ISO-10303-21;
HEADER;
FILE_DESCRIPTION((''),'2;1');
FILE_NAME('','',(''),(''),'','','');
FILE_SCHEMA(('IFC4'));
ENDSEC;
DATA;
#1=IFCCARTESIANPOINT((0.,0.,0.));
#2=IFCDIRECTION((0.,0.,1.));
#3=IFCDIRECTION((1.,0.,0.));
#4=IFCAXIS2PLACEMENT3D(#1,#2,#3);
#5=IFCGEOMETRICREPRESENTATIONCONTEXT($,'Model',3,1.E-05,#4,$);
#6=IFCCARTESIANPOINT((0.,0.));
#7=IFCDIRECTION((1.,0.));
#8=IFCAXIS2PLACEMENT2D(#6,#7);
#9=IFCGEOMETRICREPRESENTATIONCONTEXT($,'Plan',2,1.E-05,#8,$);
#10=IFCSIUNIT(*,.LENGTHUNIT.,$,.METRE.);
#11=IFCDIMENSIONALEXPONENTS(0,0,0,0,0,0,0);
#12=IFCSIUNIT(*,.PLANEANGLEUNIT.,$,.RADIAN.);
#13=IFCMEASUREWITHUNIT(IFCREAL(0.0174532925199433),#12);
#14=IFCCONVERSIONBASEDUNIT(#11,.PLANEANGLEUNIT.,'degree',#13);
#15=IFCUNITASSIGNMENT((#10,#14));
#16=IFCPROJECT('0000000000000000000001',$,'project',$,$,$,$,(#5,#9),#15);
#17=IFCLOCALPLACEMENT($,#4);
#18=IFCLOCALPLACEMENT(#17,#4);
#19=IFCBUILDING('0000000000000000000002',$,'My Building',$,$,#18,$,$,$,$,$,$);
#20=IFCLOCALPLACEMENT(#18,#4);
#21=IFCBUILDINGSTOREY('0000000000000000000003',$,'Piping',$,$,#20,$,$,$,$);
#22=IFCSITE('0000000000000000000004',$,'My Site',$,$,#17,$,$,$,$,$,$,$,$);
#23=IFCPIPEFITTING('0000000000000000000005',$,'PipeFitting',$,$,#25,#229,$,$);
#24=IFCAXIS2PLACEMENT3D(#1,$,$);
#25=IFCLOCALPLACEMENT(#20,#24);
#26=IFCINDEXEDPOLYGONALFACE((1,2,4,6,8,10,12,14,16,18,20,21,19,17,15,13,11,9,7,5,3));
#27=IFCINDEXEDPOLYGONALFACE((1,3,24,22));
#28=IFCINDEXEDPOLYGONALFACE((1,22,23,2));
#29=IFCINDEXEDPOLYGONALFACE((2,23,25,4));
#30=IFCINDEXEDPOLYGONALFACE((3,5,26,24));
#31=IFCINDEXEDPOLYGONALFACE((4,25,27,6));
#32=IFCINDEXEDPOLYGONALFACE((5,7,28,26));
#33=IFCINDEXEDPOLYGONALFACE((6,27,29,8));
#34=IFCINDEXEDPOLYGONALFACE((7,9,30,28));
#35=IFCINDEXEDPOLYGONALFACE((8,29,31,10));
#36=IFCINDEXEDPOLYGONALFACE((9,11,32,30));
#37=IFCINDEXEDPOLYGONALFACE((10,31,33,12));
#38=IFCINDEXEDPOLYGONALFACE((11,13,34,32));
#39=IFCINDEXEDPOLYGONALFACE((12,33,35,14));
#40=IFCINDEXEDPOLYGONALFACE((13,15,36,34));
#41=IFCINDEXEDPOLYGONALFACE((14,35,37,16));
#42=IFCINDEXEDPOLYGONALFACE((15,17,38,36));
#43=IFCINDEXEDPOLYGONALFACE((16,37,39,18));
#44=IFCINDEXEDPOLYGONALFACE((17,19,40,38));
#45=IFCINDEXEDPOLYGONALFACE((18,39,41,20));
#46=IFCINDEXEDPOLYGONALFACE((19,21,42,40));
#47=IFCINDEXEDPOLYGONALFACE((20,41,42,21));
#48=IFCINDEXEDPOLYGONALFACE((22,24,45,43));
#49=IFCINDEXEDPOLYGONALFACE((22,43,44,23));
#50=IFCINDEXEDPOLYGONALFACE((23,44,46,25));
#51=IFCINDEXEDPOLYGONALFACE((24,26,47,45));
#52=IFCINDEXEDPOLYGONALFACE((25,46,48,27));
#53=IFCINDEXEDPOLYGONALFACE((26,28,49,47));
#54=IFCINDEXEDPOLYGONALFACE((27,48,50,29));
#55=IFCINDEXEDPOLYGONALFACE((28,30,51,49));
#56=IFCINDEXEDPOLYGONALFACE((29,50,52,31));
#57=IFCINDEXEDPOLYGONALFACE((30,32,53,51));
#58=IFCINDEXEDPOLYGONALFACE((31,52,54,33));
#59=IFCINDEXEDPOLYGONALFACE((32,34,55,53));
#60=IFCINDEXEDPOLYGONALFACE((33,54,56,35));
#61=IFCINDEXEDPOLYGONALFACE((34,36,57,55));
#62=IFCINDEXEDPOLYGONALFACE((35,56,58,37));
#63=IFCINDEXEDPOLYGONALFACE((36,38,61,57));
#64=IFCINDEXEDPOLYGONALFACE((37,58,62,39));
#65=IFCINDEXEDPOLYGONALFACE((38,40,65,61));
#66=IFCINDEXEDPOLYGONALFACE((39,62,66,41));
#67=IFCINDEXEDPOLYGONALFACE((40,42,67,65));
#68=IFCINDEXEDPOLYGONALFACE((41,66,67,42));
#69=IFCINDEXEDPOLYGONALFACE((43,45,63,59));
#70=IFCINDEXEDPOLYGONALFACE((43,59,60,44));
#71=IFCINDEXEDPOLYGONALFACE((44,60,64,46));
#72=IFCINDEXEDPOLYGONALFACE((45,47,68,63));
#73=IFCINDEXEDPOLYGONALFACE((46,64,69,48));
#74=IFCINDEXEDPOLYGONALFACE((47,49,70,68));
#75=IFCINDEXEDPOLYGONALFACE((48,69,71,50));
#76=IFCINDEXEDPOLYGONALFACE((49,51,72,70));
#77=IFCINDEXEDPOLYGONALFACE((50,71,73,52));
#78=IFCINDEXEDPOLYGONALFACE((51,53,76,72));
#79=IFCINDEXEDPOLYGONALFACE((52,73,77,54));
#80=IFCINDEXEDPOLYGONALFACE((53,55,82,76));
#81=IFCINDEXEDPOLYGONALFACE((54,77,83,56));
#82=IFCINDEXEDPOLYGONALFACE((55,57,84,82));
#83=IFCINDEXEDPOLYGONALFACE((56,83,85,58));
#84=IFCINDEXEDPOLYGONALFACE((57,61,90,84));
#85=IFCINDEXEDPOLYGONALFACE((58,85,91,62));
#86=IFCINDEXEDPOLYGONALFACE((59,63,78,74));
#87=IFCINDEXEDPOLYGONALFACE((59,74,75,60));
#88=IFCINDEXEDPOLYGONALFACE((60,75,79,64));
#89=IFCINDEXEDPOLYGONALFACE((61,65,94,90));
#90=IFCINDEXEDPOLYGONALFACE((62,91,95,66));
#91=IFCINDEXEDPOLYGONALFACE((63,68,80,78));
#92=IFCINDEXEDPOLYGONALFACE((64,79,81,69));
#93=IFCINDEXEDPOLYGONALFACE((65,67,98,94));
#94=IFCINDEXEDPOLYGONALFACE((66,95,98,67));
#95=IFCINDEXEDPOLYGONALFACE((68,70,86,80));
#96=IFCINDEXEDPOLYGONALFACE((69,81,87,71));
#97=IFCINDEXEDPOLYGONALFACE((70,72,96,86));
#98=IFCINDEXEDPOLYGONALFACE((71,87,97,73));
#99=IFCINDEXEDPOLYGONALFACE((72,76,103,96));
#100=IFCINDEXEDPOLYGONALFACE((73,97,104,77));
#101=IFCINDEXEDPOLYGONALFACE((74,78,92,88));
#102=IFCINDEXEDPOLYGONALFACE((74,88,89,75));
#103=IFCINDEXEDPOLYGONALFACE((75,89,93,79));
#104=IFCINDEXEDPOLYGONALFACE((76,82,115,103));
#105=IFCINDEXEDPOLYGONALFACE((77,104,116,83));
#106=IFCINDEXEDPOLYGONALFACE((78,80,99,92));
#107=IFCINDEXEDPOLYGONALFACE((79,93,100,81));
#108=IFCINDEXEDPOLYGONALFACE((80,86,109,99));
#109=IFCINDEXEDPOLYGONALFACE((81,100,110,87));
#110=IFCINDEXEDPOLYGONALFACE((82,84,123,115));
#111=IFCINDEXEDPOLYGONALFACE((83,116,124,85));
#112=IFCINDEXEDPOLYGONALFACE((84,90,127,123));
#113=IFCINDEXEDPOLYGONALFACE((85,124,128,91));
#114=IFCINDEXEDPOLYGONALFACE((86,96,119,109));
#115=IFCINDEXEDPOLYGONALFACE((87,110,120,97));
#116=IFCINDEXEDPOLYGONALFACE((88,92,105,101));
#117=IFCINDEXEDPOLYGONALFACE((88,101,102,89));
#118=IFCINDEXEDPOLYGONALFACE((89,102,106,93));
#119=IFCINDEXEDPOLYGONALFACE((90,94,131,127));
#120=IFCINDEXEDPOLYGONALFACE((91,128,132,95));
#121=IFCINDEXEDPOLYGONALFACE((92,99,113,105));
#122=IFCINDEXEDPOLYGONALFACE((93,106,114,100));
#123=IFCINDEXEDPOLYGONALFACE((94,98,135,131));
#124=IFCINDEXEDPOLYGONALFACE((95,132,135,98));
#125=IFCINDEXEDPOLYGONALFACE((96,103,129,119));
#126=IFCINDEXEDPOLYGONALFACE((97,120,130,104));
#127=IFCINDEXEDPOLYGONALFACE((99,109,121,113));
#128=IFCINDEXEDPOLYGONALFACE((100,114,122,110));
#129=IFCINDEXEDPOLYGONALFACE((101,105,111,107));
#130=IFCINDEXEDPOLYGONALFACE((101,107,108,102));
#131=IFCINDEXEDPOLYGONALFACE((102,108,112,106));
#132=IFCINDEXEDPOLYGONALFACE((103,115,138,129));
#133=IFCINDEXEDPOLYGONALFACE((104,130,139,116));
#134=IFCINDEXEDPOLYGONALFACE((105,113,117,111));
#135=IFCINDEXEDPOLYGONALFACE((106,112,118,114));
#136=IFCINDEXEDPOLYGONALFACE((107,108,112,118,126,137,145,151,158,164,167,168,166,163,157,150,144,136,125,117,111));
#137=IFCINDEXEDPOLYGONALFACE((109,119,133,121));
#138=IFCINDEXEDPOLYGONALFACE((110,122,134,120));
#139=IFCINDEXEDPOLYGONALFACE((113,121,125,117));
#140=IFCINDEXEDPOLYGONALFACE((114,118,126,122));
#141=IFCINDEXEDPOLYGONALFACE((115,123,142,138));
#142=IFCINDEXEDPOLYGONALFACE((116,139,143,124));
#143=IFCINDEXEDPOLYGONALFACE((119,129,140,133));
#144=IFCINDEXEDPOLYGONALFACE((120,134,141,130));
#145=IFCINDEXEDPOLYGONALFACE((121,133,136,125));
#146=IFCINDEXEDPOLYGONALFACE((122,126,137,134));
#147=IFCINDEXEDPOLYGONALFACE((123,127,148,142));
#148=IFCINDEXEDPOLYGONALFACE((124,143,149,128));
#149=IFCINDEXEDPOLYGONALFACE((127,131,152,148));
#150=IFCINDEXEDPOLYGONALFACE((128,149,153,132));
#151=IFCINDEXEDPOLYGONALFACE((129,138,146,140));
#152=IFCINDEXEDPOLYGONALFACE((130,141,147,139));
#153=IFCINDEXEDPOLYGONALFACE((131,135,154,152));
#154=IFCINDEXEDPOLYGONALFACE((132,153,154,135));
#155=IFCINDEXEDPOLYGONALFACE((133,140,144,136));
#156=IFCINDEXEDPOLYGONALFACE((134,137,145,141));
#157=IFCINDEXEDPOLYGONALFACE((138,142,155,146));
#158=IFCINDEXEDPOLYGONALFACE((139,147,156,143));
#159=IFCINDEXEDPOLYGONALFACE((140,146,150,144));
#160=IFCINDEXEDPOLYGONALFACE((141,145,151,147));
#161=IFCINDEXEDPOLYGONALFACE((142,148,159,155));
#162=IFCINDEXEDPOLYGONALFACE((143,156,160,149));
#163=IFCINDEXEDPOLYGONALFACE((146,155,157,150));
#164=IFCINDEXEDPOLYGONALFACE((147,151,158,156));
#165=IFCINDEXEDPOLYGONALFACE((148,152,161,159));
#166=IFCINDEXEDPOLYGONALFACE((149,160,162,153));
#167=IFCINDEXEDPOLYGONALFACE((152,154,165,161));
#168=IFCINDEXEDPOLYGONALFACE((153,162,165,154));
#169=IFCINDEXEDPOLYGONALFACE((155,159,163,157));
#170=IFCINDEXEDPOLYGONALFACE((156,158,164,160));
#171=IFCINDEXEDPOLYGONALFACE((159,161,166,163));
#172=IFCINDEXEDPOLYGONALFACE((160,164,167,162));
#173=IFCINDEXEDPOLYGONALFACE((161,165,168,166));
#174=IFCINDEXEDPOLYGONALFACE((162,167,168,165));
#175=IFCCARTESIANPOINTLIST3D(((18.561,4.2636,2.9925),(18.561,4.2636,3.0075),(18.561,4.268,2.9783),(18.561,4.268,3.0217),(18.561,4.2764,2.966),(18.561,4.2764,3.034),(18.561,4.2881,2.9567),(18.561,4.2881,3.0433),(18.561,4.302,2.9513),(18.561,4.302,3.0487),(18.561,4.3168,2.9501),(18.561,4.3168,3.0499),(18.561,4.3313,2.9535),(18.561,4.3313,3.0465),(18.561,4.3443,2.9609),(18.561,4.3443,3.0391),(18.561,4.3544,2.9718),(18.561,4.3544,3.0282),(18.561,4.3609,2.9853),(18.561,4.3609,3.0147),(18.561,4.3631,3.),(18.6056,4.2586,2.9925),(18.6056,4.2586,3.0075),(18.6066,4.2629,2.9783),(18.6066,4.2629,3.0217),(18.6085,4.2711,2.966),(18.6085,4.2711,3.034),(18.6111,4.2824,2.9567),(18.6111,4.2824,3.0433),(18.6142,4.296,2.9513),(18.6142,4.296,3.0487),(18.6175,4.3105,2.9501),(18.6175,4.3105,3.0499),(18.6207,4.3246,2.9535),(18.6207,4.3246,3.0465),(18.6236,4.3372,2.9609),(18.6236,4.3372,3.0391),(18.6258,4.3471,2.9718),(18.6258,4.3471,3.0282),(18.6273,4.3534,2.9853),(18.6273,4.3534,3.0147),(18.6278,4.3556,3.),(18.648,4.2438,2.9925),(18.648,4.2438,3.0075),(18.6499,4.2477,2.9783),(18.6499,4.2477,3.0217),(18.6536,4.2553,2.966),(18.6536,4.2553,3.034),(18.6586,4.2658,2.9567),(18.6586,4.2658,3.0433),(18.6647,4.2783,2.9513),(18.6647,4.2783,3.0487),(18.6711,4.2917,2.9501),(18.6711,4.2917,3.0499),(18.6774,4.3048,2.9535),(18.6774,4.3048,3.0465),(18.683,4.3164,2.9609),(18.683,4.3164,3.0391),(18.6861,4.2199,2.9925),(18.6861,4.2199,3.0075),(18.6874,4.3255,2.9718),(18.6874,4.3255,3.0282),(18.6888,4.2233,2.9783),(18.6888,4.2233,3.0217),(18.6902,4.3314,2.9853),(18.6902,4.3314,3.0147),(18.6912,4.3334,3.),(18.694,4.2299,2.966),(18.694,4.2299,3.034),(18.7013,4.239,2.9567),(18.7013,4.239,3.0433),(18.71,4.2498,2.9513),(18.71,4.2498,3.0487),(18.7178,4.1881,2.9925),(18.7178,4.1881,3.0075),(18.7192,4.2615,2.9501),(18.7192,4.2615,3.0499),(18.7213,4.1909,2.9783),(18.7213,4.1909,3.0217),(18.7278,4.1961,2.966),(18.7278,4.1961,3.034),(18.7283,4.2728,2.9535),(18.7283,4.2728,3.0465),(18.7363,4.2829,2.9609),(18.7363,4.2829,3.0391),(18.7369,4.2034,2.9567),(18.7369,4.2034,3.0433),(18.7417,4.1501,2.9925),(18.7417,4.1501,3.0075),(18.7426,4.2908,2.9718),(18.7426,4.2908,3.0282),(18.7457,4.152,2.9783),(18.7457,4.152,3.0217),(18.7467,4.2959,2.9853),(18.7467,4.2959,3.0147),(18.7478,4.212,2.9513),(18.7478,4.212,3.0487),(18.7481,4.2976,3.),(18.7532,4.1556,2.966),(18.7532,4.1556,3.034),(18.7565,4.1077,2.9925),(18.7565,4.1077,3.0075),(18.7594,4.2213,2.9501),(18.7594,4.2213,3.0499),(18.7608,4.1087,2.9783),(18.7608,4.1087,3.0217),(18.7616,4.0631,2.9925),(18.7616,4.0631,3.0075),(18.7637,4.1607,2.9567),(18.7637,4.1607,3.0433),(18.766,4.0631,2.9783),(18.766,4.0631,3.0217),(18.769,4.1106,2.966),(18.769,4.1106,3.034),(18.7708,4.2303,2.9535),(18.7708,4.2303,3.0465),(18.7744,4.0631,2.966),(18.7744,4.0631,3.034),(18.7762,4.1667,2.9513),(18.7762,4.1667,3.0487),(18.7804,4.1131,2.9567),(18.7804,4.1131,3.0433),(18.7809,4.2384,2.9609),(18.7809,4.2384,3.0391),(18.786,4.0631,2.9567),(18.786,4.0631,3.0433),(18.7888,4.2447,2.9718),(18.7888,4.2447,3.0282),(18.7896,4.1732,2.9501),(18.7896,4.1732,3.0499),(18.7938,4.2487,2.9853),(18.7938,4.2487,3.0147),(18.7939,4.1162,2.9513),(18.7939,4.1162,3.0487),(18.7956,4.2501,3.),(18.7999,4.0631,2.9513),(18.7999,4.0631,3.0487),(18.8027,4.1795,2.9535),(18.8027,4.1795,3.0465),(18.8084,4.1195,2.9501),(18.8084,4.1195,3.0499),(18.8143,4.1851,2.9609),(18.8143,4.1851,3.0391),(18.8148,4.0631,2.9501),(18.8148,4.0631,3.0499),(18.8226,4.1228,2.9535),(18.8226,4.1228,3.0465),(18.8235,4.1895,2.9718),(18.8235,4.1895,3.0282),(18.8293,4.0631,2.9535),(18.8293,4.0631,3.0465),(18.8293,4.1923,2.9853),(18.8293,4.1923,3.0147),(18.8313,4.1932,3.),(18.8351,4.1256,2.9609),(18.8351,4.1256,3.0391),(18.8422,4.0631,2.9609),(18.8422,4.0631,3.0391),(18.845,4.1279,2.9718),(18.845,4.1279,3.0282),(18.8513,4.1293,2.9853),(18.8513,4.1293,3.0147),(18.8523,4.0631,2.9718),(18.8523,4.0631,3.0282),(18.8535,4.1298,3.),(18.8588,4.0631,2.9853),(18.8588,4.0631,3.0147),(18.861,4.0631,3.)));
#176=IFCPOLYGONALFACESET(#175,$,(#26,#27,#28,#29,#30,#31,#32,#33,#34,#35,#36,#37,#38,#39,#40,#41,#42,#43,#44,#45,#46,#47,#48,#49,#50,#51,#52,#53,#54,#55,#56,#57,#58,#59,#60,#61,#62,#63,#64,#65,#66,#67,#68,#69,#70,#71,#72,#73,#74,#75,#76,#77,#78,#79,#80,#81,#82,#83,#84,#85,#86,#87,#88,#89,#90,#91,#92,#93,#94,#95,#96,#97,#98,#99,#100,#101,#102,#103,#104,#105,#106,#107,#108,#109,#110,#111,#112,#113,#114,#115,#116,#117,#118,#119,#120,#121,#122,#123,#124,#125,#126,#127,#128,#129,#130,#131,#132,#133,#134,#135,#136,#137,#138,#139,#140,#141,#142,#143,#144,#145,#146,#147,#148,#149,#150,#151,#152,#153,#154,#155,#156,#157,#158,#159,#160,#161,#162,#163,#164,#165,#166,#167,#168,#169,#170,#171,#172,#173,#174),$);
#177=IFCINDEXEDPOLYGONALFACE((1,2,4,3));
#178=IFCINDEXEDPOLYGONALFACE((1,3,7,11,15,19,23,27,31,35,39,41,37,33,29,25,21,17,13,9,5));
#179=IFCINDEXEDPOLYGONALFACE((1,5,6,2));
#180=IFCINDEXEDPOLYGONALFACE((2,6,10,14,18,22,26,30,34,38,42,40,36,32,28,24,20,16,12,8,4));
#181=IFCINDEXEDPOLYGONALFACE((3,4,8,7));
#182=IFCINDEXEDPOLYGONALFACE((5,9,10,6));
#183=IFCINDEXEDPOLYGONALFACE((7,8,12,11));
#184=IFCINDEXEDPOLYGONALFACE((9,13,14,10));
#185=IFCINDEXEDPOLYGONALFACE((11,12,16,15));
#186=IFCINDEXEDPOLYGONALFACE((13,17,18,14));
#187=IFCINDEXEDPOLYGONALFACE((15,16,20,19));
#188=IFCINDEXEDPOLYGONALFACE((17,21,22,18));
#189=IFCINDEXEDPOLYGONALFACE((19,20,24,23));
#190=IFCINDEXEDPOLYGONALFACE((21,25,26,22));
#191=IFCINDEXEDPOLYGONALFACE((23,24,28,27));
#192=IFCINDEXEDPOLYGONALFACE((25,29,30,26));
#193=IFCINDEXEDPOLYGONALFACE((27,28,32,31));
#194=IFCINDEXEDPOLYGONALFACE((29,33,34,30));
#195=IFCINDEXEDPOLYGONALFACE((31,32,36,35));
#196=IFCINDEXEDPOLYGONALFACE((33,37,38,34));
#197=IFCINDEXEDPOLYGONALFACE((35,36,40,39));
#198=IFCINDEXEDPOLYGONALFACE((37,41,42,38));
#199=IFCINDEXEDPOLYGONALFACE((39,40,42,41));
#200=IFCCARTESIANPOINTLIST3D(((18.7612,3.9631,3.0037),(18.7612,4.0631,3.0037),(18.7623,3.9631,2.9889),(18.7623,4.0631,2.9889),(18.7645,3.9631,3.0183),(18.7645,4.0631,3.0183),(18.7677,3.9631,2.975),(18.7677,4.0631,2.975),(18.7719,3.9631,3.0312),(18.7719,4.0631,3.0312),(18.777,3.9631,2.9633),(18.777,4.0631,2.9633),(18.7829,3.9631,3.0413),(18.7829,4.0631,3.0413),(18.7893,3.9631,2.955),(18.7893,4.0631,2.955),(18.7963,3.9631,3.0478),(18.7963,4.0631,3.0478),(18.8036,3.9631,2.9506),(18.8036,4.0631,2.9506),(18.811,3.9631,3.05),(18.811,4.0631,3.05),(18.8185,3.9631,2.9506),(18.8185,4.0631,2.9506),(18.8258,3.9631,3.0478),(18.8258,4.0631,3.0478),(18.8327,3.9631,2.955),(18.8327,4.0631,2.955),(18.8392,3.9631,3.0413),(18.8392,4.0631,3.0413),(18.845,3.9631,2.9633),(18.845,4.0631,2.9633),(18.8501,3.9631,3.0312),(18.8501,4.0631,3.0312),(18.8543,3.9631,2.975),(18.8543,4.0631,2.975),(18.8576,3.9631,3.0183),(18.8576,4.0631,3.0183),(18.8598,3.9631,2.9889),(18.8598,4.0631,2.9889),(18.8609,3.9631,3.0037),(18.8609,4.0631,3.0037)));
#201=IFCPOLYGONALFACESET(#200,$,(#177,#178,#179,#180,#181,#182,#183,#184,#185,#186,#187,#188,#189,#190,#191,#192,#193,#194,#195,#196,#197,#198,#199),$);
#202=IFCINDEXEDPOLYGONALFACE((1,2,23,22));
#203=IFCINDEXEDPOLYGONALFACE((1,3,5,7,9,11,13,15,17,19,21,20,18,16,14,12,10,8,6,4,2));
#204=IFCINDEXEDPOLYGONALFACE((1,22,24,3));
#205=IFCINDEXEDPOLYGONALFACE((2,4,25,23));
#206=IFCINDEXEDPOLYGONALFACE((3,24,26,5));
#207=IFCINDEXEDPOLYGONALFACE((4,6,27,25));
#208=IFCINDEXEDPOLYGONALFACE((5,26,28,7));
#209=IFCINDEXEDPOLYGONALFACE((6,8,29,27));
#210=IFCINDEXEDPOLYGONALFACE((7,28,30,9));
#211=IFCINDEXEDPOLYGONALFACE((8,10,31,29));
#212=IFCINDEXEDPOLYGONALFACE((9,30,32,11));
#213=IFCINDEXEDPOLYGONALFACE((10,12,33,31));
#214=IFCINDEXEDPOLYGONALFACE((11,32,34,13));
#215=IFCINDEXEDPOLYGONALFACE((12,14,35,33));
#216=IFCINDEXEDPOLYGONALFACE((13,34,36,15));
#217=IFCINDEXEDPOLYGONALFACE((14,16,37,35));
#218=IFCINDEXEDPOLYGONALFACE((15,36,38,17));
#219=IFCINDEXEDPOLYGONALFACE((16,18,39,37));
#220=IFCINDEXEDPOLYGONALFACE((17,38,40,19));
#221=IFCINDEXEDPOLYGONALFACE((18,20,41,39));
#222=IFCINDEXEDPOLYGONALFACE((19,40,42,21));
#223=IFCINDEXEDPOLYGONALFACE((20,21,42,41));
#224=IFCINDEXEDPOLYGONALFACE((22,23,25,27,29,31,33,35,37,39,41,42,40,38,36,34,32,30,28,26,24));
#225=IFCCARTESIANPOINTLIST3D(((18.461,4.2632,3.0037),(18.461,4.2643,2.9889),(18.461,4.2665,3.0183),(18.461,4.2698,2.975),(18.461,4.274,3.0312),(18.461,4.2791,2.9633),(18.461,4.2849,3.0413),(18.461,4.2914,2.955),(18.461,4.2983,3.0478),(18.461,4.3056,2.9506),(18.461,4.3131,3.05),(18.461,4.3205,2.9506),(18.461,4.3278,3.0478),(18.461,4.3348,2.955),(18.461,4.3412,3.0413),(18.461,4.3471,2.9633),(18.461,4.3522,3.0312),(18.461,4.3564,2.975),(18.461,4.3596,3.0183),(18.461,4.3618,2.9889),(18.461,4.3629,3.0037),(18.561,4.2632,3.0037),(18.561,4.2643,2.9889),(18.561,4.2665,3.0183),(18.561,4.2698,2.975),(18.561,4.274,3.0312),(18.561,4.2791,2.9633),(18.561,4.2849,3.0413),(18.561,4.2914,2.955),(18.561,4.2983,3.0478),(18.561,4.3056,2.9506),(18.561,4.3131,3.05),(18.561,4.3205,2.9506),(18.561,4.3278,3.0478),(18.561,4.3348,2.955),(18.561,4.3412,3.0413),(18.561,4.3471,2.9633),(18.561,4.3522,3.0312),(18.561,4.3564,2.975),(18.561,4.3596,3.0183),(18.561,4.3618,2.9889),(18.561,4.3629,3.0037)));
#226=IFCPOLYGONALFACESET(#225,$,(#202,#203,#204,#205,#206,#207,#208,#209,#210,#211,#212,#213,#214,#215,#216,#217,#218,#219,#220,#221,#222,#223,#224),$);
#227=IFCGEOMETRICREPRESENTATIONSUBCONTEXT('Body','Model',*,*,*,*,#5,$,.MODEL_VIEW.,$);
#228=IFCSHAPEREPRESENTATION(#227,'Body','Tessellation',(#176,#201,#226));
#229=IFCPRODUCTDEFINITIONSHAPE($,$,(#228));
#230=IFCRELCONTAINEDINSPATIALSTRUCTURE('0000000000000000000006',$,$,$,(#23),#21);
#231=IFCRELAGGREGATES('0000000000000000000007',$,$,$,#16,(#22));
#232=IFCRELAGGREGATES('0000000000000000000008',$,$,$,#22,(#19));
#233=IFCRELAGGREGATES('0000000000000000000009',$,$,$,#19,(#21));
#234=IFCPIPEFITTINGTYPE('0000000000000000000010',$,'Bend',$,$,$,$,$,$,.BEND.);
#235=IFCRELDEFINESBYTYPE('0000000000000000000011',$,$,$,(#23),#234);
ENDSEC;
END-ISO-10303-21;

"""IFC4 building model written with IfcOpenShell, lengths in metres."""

from ifc_helpers import new_model, entity, si_unit, converted_unit, frame, origin_with_axes, origin_2d_with_axis, place, context, subcontext, project, spatial, circle, extrude, source, transform, mapped, type_object, type_shapes, element, save


model = new_model("IFC4")

# Units and contexts
model_context = context("Model", 3, precision=1e-05, world=origin_with_axes())
plan_context = context("Plan", 2, precision=1e-05, world=origin_2d_with_axis())
body_context = subcontext(model_context, "Body", "Model", "MODEL_VIEW")
ifc_project = project(units=[si_unit("LENGTHUNIT", "METRE"), converted_unit("PLANEANGLEUNIT", "degree", entity("IfcReal", 0.0174532925199433), si_unit("PLANEANGLEUNIT", "RADIAN"), dimensions=[0, 0, 0, 0, 0, 0, 0])], contexts=[model_context, plan_context])

# Site, building, storey
site_placement = place(None, origin_with_axes())
site = spatial("IfcSite", under=ifc_project, at=site_placement, Name="My Site")
building_placement = place(site_placement, origin_with_axes())
building = spatial("IfcBuilding", under=site, at=building_placement, Name="My Building")
storey_placement = place(building_placement, origin_with_axes())
storey = spatial("IfcBuildingStorey", under=building, at=storey_placement, Name="Piping")

# Pipe fitting
pipe_fitting_type_1 = type_object("IfcPipeFittingType", Name="Bend", PredefinedType="BEND")
shared_shape = source(origin_with_axes(), body_context, "Body", "SolidModel", [
    entity("IfcSweptDiskSolid", entity("IfcIndexedPolyCurve", entity("IfcCartesianPointList3D", [[0.0, 0.0, -0.1], [0.0, 0.0732, -0.2768], [0.0, 0.25, -0.35]]), [entity("IfcArcIndex", [1, 2, 3])]), 0.05),
    extrude(circle(Radius=0.05), origin_with_axes(), (0.0, 0.0, -1.0), 0.1),
    extrude(circle(Radius=0.05), frame((0.0, 0.25, -0.35), z_axis=(0.0, 1.0, 0.0), x_axis=(1.0, 0.0, 0.0)), (0.0, 0.0, 1.0), 0.1),
])
type_shapes(pipe_fitting_type_1, [shared_shape])
for number, where, z_axis, x_axis, name in (
    (1, (18.811, 3.9631, 3.0), (0.0, -1.0, 0.0), (0.0, 0.0, 1.0), "PipeFitting"),
):
    element("IfcPipeFitting", number, at=place(storey_placement, frame(where, z_axis=z_axis, x_axis=x_axis)), inside=storey, type_object=pipe_fitting_type_1, Name=name, context=body_context, shape_type="MappedRepresentation", body=[
        mapped(shared_shape, transform((0.0, 0.0, 0.0), x_axis=(1.0, 0.0, 0.0), y_axis=(0.0, 1.0, 0.0), z_axis=(0.0, 0.0, 1.0), scale=1.0)),
    ])

save(model, "model.ifc")
